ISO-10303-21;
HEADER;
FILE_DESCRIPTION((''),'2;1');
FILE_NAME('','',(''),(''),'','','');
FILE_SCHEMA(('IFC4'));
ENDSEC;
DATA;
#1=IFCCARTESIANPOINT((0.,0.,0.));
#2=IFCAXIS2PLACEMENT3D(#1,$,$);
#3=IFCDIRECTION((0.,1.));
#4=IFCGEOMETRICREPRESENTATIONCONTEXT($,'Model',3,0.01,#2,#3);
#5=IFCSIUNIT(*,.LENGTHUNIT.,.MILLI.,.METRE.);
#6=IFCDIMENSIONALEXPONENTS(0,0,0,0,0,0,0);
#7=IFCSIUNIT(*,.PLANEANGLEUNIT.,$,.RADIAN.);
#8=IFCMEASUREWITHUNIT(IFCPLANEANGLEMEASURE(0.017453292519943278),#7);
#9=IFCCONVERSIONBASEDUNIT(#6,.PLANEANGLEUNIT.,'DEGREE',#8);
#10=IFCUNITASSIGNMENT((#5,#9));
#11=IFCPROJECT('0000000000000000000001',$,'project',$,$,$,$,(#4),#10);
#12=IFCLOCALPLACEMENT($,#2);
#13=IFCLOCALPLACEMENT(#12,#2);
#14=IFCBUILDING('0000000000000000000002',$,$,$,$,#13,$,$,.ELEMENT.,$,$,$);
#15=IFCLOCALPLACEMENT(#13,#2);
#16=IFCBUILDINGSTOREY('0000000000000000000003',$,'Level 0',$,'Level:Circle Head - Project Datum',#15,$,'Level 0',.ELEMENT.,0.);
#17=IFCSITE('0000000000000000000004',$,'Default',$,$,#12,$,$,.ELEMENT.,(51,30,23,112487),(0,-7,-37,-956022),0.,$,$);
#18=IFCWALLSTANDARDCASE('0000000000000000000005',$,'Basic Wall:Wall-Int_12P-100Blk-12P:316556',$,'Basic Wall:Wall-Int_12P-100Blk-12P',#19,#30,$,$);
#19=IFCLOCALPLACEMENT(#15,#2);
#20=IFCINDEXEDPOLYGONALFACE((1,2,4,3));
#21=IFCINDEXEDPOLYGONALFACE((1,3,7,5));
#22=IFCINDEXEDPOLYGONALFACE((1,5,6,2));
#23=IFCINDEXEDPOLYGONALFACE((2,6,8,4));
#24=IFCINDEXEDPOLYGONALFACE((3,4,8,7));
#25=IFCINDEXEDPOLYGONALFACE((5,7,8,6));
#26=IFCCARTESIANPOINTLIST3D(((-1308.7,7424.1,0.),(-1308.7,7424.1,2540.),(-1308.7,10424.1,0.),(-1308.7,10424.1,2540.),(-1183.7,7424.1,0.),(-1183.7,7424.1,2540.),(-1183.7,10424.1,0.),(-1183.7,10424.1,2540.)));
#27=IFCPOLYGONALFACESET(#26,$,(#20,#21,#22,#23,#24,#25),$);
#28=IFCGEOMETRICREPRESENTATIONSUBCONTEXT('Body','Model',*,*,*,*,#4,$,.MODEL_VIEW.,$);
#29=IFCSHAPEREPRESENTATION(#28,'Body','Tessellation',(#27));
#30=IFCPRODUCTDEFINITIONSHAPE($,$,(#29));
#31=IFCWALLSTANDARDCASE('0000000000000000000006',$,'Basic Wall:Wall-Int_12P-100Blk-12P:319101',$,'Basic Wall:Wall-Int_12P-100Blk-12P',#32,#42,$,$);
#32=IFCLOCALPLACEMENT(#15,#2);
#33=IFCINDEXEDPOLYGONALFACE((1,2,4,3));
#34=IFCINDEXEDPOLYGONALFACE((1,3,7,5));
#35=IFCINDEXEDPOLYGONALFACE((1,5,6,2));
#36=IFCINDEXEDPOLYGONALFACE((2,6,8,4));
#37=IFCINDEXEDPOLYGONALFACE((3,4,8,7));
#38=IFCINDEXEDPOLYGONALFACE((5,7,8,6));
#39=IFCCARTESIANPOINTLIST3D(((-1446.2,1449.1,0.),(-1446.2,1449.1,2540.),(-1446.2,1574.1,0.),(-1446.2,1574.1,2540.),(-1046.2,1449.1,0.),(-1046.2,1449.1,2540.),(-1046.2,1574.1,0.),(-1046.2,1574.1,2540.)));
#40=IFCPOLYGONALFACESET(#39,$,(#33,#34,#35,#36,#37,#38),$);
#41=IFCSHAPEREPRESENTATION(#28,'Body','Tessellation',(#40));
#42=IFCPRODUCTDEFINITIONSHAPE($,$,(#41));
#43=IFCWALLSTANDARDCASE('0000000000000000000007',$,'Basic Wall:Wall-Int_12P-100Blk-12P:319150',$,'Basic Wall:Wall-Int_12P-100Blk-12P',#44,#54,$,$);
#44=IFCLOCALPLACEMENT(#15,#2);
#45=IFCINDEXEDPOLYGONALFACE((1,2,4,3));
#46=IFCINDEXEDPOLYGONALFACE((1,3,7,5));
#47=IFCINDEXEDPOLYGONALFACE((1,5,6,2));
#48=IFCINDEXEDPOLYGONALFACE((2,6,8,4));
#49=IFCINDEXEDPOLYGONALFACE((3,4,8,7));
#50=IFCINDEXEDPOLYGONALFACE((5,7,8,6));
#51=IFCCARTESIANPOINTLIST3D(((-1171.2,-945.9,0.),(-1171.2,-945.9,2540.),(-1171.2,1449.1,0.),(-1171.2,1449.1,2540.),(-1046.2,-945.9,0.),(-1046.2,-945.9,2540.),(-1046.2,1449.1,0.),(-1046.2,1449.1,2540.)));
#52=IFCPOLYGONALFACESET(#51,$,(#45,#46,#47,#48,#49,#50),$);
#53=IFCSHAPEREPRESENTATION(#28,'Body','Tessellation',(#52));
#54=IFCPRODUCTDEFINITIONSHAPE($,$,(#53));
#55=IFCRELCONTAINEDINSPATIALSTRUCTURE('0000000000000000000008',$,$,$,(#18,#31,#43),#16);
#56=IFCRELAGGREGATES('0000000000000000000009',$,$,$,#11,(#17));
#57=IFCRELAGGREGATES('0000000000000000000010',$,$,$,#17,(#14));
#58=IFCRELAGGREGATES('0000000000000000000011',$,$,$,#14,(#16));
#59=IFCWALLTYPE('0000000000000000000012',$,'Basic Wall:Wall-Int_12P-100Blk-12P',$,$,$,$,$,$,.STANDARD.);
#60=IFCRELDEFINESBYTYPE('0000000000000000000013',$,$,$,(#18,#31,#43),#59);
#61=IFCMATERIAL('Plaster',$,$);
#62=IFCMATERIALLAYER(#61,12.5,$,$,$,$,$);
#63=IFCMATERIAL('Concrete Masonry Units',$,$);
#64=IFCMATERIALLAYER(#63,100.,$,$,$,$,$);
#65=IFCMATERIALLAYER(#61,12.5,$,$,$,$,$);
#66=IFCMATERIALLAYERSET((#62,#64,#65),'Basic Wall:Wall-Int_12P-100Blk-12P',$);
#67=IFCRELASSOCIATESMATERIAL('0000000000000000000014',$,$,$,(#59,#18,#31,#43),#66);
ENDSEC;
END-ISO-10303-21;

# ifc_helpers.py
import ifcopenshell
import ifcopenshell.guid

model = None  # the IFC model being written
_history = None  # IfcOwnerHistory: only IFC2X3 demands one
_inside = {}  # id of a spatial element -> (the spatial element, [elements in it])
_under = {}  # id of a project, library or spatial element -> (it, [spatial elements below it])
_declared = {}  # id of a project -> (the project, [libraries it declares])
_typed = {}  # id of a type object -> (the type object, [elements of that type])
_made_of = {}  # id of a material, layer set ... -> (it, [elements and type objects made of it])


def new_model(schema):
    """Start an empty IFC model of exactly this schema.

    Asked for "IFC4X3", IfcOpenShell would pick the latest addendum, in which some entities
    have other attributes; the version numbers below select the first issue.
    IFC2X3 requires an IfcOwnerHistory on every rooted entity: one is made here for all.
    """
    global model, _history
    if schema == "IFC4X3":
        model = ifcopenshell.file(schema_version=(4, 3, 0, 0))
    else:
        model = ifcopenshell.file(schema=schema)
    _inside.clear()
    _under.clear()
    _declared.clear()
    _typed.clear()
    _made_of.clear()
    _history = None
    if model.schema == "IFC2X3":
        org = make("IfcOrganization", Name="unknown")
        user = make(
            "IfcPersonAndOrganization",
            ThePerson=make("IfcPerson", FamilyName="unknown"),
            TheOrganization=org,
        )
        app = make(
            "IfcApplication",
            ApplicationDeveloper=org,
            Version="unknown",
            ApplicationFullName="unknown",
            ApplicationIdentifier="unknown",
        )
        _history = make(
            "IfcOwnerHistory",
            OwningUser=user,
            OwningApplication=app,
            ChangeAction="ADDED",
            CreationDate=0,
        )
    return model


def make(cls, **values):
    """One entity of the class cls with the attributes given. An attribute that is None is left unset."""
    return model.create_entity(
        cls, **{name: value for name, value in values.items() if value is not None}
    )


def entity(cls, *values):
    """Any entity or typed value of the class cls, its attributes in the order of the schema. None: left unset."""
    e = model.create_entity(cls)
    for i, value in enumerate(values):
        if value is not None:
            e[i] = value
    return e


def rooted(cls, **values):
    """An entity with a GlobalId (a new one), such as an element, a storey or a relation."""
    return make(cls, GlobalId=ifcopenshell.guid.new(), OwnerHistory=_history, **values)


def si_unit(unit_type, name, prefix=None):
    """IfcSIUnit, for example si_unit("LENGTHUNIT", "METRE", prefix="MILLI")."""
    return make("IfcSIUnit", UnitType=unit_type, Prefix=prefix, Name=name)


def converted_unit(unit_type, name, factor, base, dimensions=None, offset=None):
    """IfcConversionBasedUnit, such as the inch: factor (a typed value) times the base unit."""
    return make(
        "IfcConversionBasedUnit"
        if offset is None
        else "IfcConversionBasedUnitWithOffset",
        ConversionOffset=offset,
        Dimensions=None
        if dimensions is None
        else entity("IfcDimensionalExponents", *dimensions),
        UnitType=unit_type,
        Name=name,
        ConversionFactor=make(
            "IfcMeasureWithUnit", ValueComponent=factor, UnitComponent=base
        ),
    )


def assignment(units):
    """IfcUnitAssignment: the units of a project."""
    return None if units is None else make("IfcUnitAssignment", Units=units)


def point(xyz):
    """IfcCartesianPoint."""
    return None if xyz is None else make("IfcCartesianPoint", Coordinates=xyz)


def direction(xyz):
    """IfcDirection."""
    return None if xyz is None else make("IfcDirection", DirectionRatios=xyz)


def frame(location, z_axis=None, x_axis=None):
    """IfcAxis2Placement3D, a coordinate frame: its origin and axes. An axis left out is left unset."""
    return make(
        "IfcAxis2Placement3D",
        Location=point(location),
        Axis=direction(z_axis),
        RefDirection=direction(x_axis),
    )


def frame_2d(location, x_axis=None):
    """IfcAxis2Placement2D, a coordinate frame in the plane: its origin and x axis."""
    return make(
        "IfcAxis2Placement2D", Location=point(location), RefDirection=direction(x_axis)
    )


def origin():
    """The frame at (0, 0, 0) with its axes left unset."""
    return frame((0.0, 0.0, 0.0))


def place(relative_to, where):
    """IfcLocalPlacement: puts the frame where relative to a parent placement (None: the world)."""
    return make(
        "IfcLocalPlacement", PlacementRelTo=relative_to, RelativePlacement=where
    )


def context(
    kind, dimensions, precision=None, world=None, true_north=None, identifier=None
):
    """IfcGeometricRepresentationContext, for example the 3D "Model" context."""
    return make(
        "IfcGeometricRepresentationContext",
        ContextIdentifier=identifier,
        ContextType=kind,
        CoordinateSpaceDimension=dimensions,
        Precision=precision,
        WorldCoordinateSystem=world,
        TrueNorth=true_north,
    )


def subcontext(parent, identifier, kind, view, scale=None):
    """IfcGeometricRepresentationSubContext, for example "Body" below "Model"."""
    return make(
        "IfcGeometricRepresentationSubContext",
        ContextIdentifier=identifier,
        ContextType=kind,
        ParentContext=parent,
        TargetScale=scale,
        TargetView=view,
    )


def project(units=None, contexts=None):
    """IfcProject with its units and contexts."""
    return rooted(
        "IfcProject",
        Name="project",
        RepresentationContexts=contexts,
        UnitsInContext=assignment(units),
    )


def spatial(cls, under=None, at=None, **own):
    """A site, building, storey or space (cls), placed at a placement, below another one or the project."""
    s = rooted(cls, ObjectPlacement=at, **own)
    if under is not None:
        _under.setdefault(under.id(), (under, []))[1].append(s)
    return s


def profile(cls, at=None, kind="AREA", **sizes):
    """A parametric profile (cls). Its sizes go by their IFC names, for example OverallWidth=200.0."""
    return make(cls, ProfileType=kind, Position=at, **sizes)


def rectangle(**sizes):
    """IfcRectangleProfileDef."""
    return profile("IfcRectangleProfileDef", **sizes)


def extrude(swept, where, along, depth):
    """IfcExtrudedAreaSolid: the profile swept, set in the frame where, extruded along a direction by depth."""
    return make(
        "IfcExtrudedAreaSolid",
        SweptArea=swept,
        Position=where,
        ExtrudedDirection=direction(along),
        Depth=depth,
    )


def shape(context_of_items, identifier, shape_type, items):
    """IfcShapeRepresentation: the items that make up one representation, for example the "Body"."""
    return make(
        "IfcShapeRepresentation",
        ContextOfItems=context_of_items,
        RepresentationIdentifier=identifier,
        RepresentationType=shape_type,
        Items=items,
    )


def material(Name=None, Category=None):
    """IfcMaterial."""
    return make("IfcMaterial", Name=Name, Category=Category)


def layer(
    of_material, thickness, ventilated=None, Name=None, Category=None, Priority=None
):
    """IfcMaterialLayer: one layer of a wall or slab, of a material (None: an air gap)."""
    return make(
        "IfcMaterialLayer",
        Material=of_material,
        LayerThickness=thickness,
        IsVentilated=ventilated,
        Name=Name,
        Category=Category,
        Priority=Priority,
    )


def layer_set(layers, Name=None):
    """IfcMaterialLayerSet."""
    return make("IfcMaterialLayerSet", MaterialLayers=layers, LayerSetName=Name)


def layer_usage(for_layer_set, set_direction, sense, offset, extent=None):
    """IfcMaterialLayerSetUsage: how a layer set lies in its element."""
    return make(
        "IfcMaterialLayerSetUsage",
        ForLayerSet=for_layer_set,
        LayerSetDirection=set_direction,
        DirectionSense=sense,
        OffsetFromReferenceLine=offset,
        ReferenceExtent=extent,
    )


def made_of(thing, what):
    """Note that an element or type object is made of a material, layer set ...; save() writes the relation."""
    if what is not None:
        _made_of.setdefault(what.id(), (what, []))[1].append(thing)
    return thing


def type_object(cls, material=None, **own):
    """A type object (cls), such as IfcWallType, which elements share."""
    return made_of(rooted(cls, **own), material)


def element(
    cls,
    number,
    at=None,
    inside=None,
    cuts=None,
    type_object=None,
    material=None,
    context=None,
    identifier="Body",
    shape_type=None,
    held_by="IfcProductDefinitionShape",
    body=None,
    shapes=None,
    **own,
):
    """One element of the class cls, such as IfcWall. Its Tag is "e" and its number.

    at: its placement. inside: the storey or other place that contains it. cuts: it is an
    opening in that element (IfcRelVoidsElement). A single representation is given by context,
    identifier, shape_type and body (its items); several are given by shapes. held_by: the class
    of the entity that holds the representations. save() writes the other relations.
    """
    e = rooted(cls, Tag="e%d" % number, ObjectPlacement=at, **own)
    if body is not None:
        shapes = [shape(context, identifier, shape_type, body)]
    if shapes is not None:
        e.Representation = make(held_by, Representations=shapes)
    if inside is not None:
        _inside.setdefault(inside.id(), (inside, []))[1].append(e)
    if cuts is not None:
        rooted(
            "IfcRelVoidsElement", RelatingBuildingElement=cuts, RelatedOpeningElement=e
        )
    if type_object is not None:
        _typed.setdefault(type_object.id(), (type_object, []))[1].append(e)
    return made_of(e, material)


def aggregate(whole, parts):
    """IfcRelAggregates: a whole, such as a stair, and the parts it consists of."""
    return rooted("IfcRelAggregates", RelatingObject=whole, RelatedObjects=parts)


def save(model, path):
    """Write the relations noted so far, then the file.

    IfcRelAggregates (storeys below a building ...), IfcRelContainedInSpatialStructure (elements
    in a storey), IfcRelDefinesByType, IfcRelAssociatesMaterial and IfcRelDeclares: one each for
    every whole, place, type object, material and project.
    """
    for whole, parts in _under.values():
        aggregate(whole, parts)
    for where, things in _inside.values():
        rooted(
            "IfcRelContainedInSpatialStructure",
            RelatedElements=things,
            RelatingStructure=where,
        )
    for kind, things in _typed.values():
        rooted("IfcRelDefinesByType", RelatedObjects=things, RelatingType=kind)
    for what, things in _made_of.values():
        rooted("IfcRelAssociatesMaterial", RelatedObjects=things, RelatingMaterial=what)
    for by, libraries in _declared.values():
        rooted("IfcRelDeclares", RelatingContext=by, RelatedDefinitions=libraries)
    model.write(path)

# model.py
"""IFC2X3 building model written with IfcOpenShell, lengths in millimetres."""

from ifc_helpers import new_model, entity, si_unit, converted_unit, direction, frame, frame_2d, origin, place, context, subcontext, project, spatial, rectangle, extrude, material, layer, layer_set, layer_usage, type_object, element, save


model = new_model("IFC2X3")

# Units and contexts
model_context = context("Model", 3, precision=0.01, world=origin(), true_north=direction((0.0, 1.0)))
body_context = subcontext(model_context, "Body", "Model", "MODEL_VIEW")
ifc_project = project(units=[si_unit("LENGTHUNIT", "METRE", prefix="MILLI"), converted_unit("PLANEANGLEUNIT", "DEGREE", entity("IfcPlaneAngleMeasure", 0.017453292519943278), si_unit("PLANEANGLEUNIT", "RADIAN"), dimensions=[0, 0, 0, 0, 0, 0, 0])], contexts=[model_context])

# Site, building, storey
site_placement = place(None, origin())
site = spatial("IfcSite", under=ifc_project, at=site_placement, Name="Default", CompositionType="ELEMENT", RefLatitude=(51, 30, 23, 112487), RefLongitude=(0, -7, -37, -956022), RefElevation=0.0)
building_placement = place(site_placement, origin())
building = spatial("IfcBuilding", under=site, at=building_placement, CompositionType="ELEMENT")
storey_placement = place(building_placement, origin())
storey = spatial("IfcBuildingStorey", under=building, at=storey_placement, Name="Level 0", ObjectType="Level:Circle Head - Project Datum", LongName="Level 0", CompositionType="ELEMENT", Elevation=0.0)

# Shared definitions
ifc_material_1 = material(Name="Plaster")
ifc_layer_1 = layer(ifc_material_1, 12.5)
ifc_material_2 = material(Name="Concrete Masonry Units")
ifc_layer_2 = layer(ifc_material_2, 100.0)
ifc_layer_3 = layer(ifc_material_1, 12.5)
ifc_layer_set_1 = layer_set([ifc_layer_1, ifc_layer_2, ifc_layer_3], Name="Basic Wall:Wall-Int_12P-100Blk-12P")
ifc_layer_usage_1 = layer_usage(ifc_layer_set_1, "AXIS2", "NEGATIVE", 62.5)
wall_type_1 = type_object("IfcWallType", Name="Basic Wall:Wall-Int_12P-100Blk-12P", PredefinedType="STANDARD", material=ifc_layer_set_1)

# Walls
wall_1_placement = place(storey_placement, frame((-1246.2, 10424.1, 0.0), z_axis=(0.0, 0.0, 1.0), x_axis=(0.0, -1.0, 0.0)))
element("IfcWallStandardCase", 1, at=wall_1_placement, inside=storey, type_object=wall_type_1, material=ifc_layer_usage_1, Name="Basic Wall:Wall-Int_12P-100Blk-12P:316556", ObjectType="Basic Wall:Wall-Int_12P-100Blk-12P", context=body_context, shape_type="SweptSolid", body=[
    extrude(rectangle(XDim=3000.0, YDim=125.0, at=frame_2d((1500.0, 0.0), x_axis=(-1.0, 0.0))), origin(), (0.0, 0.0, 1.0), 2540.0),
])
wall_2_placement = place(storey_placement, frame((-1446.2, 1511.6, 0.0)))
element("IfcWallStandardCase", 2, at=wall_2_placement, inside=storey, type_object=wall_type_1, material=ifc_layer_usage_1, Name="Basic Wall:Wall-Int_12P-100Blk-12P:319101", ObjectType="Basic Wall:Wall-Int_12P-100Blk-12P", context=body_context, shape_type="SweptSolid", body=[
    extrude(rectangle(XDim=400.0, YDim=125.0, at=frame_2d((200.0, 0.0), x_axis=(-1.0, 0.0))), origin(), (0.0, 0.0, 1.0), 2540.0),
])
wall_3_placement = place(storey_placement, frame((-1108.7, 1449.1, 0.0), z_axis=(0.0, 0.0, 1.0), x_axis=(0.0, -1.0, 0.0)))
element("IfcWallStandardCase", 3, at=wall_3_placement, inside=storey, type_object=wall_type_1, material=ifc_layer_usage_1, Name="Basic Wall:Wall-Int_12P-100Blk-12P:319150", ObjectType="Basic Wall:Wall-Int_12P-100Blk-12P", context=body_context, shape_type="SweptSolid", body=[
    extrude(rectangle(XDim=2395.0, YDim=125.0, at=frame_2d((1197.5, 0.0), x_axis=(-1.0, 0.0))), origin(), (0.0, 0.0, 1.0), 2540.0),
])

save(model, "model.ifc")
